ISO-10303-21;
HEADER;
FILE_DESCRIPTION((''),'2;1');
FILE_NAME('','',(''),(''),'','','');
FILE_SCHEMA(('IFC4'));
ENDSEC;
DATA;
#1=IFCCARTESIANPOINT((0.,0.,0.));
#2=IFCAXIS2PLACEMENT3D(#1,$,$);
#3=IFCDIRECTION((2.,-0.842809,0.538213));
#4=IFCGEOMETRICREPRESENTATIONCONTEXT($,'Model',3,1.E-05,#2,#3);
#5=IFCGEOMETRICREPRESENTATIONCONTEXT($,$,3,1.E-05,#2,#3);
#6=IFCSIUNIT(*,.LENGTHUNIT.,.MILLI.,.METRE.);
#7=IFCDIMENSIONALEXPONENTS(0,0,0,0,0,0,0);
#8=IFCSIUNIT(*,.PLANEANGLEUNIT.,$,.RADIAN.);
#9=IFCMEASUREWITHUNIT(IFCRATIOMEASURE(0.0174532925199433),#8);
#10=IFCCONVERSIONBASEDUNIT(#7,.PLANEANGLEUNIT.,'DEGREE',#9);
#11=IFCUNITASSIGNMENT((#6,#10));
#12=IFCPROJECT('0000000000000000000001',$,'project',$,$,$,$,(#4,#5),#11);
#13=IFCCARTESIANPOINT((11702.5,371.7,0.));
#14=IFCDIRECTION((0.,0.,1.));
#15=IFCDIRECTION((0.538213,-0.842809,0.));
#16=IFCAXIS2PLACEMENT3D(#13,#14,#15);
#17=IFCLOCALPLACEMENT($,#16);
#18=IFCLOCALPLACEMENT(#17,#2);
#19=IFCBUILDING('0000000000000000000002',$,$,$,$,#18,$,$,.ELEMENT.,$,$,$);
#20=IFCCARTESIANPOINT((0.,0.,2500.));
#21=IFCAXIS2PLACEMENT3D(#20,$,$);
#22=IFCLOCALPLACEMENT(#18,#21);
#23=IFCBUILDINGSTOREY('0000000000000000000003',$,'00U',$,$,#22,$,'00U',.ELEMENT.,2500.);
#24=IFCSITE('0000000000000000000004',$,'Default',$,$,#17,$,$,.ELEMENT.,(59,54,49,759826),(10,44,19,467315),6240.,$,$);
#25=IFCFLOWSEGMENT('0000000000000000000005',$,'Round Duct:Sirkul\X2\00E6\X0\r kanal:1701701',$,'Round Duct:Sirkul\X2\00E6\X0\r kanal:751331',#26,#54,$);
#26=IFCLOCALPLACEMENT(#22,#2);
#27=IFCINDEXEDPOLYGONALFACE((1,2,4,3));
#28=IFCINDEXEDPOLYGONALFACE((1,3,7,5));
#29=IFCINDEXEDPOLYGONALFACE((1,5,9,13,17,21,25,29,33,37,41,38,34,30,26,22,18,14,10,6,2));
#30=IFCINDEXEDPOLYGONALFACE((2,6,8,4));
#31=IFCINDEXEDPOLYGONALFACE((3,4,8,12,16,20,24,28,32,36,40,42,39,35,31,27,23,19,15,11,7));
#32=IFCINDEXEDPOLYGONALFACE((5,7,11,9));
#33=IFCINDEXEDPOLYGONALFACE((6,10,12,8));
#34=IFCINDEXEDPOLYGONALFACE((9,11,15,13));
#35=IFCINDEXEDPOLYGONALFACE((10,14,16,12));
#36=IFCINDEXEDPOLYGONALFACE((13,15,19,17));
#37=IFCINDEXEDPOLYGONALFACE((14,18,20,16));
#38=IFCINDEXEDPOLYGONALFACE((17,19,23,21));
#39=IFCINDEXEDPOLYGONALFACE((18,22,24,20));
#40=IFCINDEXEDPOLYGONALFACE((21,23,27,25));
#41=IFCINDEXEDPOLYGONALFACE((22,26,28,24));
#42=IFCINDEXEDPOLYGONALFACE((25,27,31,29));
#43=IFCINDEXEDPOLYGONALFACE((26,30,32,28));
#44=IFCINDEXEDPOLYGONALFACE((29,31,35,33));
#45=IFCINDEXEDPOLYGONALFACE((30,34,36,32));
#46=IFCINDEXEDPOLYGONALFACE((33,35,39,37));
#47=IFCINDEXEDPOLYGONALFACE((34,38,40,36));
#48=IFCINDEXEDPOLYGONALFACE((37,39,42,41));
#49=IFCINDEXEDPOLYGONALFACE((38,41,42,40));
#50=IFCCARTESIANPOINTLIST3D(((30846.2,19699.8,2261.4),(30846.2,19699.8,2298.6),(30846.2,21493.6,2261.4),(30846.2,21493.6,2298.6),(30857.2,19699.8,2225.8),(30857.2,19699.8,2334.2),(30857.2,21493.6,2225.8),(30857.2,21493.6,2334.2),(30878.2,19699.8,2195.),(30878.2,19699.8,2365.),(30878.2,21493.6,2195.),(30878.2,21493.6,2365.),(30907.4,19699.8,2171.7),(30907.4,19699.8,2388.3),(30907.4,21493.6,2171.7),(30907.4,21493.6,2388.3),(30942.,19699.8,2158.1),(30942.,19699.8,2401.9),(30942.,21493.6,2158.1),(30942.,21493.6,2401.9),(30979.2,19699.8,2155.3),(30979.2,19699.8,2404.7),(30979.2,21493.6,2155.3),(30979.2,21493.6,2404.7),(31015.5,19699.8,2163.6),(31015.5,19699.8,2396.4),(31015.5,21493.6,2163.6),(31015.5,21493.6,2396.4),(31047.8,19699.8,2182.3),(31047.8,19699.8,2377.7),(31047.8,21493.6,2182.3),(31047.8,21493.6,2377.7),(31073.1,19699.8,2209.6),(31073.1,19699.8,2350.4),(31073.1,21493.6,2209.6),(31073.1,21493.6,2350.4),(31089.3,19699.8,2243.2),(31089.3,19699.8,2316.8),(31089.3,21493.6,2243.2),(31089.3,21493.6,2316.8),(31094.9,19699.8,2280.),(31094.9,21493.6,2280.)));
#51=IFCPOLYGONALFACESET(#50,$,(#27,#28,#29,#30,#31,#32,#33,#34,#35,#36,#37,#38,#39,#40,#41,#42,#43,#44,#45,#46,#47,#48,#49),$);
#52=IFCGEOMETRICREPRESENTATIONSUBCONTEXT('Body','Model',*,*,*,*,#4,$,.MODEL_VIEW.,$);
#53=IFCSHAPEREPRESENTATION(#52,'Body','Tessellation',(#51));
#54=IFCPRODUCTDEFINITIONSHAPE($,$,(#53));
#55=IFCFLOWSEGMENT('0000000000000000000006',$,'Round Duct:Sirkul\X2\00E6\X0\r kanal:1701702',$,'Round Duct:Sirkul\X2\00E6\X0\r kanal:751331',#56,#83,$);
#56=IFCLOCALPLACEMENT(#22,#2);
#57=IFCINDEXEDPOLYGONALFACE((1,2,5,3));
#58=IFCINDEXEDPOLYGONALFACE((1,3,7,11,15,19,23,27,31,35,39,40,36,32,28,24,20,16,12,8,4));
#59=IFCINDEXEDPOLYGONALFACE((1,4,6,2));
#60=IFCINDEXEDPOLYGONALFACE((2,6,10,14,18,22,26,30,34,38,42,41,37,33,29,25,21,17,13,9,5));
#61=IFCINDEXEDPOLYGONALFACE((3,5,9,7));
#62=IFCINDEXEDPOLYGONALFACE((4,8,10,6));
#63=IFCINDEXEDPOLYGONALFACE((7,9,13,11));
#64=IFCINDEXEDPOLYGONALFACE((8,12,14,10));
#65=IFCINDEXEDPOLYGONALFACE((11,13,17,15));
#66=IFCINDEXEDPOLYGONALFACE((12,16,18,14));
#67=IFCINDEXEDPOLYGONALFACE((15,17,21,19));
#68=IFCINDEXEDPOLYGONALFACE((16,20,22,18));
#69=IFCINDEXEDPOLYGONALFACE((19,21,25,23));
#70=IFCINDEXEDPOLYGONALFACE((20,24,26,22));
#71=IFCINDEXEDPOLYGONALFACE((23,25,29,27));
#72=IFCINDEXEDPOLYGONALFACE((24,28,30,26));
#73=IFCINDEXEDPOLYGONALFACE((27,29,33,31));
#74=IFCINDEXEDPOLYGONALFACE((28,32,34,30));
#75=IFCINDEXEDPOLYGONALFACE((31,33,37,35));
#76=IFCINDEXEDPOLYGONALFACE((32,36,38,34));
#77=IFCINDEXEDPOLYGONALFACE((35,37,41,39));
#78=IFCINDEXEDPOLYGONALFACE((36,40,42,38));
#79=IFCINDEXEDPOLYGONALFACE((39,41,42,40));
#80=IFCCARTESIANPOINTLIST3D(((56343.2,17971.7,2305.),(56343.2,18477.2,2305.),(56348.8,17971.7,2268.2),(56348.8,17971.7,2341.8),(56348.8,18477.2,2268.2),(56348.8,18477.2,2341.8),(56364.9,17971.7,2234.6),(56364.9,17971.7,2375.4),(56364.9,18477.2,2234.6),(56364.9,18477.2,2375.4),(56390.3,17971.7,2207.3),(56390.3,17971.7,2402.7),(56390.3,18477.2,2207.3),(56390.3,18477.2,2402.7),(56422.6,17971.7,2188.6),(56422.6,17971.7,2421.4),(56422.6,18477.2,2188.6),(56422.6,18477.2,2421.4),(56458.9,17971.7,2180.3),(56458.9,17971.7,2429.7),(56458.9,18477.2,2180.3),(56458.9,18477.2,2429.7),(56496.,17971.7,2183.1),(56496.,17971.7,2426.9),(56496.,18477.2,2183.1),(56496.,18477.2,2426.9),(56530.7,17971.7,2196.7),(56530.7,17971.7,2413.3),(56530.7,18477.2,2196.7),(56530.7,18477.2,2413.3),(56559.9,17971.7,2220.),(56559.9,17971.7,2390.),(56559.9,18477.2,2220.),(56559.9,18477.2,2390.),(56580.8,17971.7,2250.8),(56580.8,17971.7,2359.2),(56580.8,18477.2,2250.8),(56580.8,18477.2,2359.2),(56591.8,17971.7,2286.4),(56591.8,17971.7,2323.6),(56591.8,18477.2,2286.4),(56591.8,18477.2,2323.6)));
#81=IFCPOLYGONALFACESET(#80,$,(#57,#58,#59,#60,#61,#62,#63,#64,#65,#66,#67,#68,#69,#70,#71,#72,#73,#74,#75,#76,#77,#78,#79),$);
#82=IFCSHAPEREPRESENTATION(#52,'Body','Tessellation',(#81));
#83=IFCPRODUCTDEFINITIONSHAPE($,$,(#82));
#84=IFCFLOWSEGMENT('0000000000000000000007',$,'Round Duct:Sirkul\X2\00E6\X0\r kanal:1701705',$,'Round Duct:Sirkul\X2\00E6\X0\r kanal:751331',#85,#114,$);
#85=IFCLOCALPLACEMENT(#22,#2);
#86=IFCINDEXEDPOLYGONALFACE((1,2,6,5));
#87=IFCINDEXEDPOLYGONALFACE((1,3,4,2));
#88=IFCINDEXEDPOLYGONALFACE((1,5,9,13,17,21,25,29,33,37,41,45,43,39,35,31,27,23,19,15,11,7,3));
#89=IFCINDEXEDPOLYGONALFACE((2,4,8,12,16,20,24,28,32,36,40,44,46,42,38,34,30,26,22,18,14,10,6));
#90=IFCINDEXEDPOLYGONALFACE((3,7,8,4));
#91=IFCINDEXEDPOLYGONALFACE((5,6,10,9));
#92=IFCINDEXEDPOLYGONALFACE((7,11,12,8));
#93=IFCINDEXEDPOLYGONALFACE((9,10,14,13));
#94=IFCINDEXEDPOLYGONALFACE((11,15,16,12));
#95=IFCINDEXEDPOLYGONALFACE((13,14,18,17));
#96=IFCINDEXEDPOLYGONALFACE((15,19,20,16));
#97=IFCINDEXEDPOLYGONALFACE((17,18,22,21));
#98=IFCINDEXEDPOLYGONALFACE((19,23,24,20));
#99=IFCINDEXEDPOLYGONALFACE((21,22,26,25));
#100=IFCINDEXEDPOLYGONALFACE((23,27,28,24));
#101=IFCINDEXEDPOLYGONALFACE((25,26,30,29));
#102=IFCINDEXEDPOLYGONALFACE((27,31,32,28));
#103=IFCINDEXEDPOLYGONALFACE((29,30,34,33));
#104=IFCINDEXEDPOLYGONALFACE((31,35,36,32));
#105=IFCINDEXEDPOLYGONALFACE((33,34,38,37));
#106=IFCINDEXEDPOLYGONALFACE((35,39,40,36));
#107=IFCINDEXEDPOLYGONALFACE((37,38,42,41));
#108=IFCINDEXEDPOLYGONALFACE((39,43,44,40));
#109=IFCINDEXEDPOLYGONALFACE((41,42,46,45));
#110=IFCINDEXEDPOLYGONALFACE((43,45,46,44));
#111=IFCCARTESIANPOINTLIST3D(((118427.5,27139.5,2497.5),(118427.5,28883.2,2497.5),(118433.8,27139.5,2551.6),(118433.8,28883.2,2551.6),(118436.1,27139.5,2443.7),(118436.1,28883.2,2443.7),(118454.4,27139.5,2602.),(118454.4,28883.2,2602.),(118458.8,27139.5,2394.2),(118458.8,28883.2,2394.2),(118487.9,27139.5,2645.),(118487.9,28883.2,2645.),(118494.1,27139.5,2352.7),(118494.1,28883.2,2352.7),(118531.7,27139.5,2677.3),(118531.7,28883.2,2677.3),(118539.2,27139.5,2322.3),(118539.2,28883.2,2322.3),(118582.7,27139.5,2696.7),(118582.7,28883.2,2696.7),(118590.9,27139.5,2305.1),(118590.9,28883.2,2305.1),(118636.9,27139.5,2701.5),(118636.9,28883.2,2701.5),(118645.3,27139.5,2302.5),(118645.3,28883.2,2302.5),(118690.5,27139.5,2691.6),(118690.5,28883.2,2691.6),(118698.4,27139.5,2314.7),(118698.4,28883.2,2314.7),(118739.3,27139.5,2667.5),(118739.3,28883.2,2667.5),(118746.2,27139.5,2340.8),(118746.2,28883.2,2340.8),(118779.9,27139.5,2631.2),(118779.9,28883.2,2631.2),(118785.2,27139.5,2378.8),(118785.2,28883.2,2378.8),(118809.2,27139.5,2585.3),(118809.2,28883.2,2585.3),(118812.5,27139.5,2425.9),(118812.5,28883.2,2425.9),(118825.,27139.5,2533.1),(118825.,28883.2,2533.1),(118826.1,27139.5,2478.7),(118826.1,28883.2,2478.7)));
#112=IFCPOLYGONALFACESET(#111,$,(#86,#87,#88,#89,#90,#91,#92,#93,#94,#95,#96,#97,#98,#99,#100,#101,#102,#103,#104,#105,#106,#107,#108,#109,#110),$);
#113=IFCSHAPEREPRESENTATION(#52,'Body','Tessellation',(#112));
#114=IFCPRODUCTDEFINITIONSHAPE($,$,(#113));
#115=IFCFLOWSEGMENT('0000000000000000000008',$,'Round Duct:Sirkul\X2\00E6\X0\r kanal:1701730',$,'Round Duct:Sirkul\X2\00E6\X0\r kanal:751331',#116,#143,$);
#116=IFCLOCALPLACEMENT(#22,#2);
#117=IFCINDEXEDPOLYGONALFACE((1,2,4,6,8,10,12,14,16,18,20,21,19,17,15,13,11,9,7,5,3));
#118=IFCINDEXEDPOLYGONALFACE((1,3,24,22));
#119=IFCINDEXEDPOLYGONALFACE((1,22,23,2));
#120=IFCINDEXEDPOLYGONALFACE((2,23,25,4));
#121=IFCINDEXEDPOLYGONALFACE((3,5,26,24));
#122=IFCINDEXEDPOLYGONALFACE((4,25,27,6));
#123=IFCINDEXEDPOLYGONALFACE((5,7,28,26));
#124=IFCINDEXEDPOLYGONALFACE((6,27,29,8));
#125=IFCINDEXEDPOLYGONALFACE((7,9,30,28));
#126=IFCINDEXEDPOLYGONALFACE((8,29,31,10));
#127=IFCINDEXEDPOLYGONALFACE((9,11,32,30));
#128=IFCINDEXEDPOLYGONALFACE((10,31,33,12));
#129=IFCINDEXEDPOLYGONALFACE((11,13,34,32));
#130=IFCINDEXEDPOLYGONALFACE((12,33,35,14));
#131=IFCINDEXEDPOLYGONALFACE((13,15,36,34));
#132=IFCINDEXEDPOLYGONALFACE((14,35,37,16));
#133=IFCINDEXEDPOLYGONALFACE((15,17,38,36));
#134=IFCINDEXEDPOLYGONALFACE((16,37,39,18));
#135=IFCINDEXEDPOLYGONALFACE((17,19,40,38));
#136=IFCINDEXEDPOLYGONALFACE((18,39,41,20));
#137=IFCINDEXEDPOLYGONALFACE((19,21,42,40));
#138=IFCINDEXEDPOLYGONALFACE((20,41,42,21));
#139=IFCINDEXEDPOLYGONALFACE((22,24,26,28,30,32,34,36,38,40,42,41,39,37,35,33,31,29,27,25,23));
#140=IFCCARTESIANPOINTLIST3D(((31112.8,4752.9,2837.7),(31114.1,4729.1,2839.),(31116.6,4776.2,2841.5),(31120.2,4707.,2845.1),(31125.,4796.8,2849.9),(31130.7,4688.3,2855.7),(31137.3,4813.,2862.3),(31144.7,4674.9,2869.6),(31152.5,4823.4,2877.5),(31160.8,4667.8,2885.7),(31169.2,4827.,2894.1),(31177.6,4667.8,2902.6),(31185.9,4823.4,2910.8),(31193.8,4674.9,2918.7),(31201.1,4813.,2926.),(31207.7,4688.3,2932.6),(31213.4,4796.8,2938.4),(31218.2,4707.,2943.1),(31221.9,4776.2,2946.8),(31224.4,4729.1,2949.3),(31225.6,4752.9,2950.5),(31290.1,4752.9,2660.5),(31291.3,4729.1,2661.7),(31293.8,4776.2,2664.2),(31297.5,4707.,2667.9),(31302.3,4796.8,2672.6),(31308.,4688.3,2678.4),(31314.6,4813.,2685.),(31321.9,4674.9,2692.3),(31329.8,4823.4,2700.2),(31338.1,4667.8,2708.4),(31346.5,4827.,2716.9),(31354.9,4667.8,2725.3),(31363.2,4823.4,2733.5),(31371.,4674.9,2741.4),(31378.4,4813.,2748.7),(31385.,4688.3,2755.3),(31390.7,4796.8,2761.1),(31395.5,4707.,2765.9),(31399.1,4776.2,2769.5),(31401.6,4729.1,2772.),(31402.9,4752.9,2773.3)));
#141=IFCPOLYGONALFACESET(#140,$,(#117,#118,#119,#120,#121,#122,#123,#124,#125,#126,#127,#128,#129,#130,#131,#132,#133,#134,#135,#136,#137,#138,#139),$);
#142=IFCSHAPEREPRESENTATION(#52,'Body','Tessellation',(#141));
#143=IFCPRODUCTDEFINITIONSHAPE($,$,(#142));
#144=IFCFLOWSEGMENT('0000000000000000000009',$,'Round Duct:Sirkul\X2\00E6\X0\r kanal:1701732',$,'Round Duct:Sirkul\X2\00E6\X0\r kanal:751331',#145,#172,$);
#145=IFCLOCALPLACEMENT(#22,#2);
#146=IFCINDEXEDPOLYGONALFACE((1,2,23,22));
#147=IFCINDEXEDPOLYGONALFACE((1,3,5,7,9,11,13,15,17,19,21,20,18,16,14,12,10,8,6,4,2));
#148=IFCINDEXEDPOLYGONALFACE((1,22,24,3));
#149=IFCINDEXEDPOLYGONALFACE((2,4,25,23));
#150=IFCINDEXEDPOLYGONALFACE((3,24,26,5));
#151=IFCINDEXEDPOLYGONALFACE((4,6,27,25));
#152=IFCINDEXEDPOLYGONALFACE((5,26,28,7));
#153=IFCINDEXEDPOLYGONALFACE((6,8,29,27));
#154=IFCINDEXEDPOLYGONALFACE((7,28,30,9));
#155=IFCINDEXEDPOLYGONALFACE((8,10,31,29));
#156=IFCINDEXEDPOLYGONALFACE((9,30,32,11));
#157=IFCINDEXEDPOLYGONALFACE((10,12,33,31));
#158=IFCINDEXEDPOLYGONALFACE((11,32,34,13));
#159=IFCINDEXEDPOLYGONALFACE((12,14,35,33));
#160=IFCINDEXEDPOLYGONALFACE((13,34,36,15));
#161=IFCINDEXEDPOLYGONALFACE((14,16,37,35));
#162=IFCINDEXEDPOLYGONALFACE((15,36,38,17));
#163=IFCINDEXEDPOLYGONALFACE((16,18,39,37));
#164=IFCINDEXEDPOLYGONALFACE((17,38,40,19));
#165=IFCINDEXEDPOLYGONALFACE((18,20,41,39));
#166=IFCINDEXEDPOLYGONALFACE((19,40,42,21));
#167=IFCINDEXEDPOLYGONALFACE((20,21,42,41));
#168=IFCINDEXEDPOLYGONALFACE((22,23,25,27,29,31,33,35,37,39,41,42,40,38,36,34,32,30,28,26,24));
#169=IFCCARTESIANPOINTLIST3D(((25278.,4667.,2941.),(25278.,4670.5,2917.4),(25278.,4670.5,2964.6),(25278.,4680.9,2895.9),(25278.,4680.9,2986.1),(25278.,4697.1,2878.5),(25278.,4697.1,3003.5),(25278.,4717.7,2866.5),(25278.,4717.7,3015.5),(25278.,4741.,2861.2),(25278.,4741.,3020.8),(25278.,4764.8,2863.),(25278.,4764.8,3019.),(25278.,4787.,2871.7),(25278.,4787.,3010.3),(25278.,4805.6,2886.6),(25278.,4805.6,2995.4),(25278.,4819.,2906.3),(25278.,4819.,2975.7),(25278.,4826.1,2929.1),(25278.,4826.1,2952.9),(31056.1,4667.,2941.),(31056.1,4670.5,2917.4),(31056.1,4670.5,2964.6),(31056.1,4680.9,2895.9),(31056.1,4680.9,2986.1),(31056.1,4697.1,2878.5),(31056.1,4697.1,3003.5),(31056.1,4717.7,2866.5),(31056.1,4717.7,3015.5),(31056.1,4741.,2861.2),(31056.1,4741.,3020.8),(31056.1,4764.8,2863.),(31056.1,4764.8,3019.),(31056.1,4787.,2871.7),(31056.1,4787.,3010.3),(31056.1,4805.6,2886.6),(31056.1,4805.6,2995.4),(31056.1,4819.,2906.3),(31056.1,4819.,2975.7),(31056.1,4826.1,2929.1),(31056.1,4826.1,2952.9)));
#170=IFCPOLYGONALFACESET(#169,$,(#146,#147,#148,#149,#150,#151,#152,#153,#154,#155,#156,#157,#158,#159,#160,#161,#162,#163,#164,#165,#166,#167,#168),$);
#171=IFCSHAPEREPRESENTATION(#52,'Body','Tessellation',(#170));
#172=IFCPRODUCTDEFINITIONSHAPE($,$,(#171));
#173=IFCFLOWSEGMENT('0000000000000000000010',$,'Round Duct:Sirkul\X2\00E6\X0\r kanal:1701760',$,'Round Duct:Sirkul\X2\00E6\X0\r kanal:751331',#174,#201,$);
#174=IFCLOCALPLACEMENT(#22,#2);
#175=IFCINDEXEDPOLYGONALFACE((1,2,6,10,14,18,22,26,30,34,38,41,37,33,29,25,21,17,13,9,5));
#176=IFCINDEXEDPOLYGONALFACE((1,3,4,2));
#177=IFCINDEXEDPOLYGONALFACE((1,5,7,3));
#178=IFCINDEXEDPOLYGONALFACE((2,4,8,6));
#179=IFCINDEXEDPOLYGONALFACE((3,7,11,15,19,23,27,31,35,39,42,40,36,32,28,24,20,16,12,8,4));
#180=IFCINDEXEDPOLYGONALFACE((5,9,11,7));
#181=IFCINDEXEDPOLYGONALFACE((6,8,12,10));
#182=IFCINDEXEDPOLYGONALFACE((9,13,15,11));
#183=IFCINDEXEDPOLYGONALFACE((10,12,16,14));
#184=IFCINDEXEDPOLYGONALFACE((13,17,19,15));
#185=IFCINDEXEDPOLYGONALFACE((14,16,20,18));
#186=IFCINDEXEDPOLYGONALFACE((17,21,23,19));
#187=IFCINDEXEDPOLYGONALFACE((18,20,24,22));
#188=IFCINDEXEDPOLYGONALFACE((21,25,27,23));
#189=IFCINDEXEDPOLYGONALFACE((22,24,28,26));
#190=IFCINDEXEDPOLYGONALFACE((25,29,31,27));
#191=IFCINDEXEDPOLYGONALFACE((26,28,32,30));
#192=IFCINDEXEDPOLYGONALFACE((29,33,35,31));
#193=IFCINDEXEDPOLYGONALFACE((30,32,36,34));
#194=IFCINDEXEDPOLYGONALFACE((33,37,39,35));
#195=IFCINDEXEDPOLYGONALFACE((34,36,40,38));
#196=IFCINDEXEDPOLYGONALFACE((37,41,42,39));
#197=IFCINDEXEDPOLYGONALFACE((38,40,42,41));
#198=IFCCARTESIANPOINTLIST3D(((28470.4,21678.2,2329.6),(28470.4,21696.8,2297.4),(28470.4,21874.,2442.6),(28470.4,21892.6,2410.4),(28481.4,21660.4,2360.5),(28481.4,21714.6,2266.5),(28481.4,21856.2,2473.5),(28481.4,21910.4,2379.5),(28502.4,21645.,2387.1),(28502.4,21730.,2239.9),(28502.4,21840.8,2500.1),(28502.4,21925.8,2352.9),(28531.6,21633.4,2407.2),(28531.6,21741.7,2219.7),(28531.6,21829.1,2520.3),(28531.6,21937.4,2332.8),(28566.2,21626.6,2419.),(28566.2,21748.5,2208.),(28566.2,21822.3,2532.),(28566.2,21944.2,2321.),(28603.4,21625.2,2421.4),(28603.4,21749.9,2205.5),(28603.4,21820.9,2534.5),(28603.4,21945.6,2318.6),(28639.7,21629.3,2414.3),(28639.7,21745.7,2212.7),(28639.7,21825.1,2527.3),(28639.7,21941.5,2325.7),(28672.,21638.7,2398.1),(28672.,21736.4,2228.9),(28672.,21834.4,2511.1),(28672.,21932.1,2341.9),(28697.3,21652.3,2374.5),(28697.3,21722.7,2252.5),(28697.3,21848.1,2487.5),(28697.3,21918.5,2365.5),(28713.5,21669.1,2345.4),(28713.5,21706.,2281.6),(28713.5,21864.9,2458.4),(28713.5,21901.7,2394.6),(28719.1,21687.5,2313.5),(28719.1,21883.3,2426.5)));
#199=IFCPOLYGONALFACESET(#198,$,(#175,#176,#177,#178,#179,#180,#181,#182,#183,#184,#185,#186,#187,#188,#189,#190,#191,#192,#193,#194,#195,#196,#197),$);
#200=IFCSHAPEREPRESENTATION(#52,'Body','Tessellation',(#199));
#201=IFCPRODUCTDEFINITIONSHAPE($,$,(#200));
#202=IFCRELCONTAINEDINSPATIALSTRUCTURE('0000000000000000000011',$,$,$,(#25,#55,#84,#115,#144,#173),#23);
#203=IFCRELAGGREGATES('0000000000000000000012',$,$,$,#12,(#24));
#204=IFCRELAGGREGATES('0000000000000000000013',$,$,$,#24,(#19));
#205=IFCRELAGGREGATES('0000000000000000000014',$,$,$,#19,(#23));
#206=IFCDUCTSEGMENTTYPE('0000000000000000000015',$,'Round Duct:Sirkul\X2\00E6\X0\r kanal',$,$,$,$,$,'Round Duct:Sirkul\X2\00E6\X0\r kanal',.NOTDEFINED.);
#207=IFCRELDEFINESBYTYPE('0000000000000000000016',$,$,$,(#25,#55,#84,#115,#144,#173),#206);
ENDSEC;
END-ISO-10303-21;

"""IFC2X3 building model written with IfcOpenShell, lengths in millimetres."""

from ifc_helpers import new_model, entity, si_unit, converted_unit, direction, frame, frame_2d, origin, origin_2d_with_axis, place, context, subcontext, project, spatial, circle, extrude, type_object, element, save


model = new_model("IFC2X3")

# Units and contexts
model_context = context("Model", 3, precision=1e-05, world=origin(), true_north=direction((2.0, -0.842809, 0.538213)))
context_of_model = context(None, 3, precision=1e-05, world=origin(), true_north=direction((2.0, -0.842809, 0.538213)))
body_context = subcontext(model_context, "Body", "Model", "MODEL_VIEW")
ifc_project = project(units=[si_unit("LENGTHUNIT", "METRE", prefix="MILLI"), converted_unit("PLANEANGLEUNIT", "DEGREE", entity("IfcRatioMeasure", 0.0174532925199433), si_unit("PLANEANGLEUNIT", "RADIAN"), dimensions=[0, 0, 0, 0, 0, 0, 0])], contexts=[model_context, context_of_model])

# Site, building, storey
site_placement = place(None, frame((11702.5, 371.7, 0.0), z_axis=(0.0, 0.0, 1.0), x_axis=(0.538213, -0.842809, 0.0)))
site = spatial("IfcSite", under=ifc_project, at=site_placement, Name="Default", CompositionType="ELEMENT", RefLatitude=(59, 54, 49, 759826), RefLongitude=(10, 44, 19, 467315), RefElevation=6240.0)
building_placement = place(site_placement, origin())
building = spatial("IfcBuilding", under=site, at=building_placement, CompositionType="ELEMENT")
storey_placement = place(building_placement, frame((0.0, 0.0, 2500.0)))
storey = spatial("IfcBuildingStorey", under=building, at=storey_placement, Name="00U", LongName="00U", CompositionType="ELEMENT", Elevation=2500.0)

# Flow segments
duct_segment_type = type_object("IfcDuctSegmentType", Name="Round Duct:Sirkulær kanal", ElementType="Round Duct:Sirkulær kanal", PredefinedType="NOTDEFINED")
flow_segment_1_placement = place(storey_placement, origin())
element("IfcFlowSegment", 1, at=flow_segment_1_placement, inside=storey, type_object=duct_segment_type, Name="Round Duct:Sirkulær kanal:1701701", ObjectType="Round Duct:Sirkulær kanal:751331", context=body_context, shape_type="SweptSolid", body=[
    extrude(circle(Radius=125.0, at=origin_2d_with_axis()), frame((30969.9, 19699.8, 2280.0), z_axis=(0.0, 1.0, 0.0), x_axis=(1.0, 0.0, 0.0)), (0.0, 0.0, 1.0), 1793.9),
])
flow_segment_2_placement = place(storey_placement, origin())
element("IfcFlowSegment", 2, at=flow_segment_2_placement, inside=storey, type_object=duct_segment_type, Name="Round Duct:Sirkulær kanal:1701702", ObjectType="Round Duct:Sirkulær kanal:751331", context=body_context, shape_type="SweptSolid", body=[
    extrude(circle(Radius=125.0, at=origin_2d_with_axis()), frame((56468.2, 17971.7, 2305.0), z_axis=(0.0, 1.0, 0.0), x_axis=(-1.0, 0.0, 0.0)), (0.0, 0.0, 1.0), 505.5),
])
flow_segment_3_placement = place(storey_placement, origin())
element("IfcFlowSegment", 3, at=flow_segment_3_placement, inside=storey, type_object=duct_segment_type, Name="Round Duct:Sirkulær kanal:1701705", ObjectType="Round Duct:Sirkulær kanal:751331", context=body_context, shape_type="SweptSolid", body=[
    extrude(circle(Radius=200.0, at=frame_2d((0.0, 0.0), x_axis=(1.0, 0.0))), frame((118627.5, 27139.5, 2501.7), z_axis=(0.0, 1.0, 0.0), x_axis=(-0.999779, 0.0, -0.021033)), (0.0, 0.0, 1.0), 1743.8),
])
flow_segment_4_placement = place(storey_placement, origin())
element("IfcFlowSegment", 4, at=flow_segment_4_placement, inside=storey, type_object=duct_segment_type, Name="Round Duct:Sirkulær kanal:1701730", ObjectType="Round Duct:Sirkulær kanal:751331", context=body_context, shape_type="SweptSolid", body=[
    extrude(circle(Radius=80.0, at=origin_2d_with_axis()), frame((31346.5, 4747.0, 2716.9), z_axis=(-0.707107, 0.0, 0.707107), x_axis=(0.0, 1.0, 0.0)), (0.0, 0.0, 1.0), 250.7),
])
flow_segment_5_placement = place(storey_placement, origin())
element("IfcFlowSegment", 5, at=flow_segment_5_placement, inside=storey, type_object=duct_segment_type, Name="Round Duct:Sirkulær kanal:1701732", ObjectType="Round Duct:Sirkulær kanal:751331", context=body_context, shape_type="SweptSolid", body=[
    extrude(circle(Radius=80.0, at=origin_2d_with_axis()), frame((25278.0, 4747.0, 2941.0), z_axis=(1.0, 0.0, 0.0), x_axis=(0.0, -1.0, 0.0)), (0.0, 0.0, 1.0), 5778.1),
])
flow_segment_6_placement = place(storey_placement, origin())
element("IfcFlowSegment", 6, at=flow_segment_6_placement, inside=storey, type_object=duct_segment_type, Name="Round Duct:Sirkulær kanal:1701760", ObjectType="Round Duct:Sirkulær kanal:751331", context=body_context, shape_type="SweptSolid", body=[
    extrude(circle(Radius=125.0, at=frame_2d((0.0, 0.0), x_axis=(1.0, 0.0))), frame((28594.1, 21687.5, 2313.5), z_axis=(0.0, 0.866025, 0.5), x_axis=(1.0, 0.0, 0.0)), (0.0, 0.0, 1.0), 226.0),
])

save(model, "model.ifc")
